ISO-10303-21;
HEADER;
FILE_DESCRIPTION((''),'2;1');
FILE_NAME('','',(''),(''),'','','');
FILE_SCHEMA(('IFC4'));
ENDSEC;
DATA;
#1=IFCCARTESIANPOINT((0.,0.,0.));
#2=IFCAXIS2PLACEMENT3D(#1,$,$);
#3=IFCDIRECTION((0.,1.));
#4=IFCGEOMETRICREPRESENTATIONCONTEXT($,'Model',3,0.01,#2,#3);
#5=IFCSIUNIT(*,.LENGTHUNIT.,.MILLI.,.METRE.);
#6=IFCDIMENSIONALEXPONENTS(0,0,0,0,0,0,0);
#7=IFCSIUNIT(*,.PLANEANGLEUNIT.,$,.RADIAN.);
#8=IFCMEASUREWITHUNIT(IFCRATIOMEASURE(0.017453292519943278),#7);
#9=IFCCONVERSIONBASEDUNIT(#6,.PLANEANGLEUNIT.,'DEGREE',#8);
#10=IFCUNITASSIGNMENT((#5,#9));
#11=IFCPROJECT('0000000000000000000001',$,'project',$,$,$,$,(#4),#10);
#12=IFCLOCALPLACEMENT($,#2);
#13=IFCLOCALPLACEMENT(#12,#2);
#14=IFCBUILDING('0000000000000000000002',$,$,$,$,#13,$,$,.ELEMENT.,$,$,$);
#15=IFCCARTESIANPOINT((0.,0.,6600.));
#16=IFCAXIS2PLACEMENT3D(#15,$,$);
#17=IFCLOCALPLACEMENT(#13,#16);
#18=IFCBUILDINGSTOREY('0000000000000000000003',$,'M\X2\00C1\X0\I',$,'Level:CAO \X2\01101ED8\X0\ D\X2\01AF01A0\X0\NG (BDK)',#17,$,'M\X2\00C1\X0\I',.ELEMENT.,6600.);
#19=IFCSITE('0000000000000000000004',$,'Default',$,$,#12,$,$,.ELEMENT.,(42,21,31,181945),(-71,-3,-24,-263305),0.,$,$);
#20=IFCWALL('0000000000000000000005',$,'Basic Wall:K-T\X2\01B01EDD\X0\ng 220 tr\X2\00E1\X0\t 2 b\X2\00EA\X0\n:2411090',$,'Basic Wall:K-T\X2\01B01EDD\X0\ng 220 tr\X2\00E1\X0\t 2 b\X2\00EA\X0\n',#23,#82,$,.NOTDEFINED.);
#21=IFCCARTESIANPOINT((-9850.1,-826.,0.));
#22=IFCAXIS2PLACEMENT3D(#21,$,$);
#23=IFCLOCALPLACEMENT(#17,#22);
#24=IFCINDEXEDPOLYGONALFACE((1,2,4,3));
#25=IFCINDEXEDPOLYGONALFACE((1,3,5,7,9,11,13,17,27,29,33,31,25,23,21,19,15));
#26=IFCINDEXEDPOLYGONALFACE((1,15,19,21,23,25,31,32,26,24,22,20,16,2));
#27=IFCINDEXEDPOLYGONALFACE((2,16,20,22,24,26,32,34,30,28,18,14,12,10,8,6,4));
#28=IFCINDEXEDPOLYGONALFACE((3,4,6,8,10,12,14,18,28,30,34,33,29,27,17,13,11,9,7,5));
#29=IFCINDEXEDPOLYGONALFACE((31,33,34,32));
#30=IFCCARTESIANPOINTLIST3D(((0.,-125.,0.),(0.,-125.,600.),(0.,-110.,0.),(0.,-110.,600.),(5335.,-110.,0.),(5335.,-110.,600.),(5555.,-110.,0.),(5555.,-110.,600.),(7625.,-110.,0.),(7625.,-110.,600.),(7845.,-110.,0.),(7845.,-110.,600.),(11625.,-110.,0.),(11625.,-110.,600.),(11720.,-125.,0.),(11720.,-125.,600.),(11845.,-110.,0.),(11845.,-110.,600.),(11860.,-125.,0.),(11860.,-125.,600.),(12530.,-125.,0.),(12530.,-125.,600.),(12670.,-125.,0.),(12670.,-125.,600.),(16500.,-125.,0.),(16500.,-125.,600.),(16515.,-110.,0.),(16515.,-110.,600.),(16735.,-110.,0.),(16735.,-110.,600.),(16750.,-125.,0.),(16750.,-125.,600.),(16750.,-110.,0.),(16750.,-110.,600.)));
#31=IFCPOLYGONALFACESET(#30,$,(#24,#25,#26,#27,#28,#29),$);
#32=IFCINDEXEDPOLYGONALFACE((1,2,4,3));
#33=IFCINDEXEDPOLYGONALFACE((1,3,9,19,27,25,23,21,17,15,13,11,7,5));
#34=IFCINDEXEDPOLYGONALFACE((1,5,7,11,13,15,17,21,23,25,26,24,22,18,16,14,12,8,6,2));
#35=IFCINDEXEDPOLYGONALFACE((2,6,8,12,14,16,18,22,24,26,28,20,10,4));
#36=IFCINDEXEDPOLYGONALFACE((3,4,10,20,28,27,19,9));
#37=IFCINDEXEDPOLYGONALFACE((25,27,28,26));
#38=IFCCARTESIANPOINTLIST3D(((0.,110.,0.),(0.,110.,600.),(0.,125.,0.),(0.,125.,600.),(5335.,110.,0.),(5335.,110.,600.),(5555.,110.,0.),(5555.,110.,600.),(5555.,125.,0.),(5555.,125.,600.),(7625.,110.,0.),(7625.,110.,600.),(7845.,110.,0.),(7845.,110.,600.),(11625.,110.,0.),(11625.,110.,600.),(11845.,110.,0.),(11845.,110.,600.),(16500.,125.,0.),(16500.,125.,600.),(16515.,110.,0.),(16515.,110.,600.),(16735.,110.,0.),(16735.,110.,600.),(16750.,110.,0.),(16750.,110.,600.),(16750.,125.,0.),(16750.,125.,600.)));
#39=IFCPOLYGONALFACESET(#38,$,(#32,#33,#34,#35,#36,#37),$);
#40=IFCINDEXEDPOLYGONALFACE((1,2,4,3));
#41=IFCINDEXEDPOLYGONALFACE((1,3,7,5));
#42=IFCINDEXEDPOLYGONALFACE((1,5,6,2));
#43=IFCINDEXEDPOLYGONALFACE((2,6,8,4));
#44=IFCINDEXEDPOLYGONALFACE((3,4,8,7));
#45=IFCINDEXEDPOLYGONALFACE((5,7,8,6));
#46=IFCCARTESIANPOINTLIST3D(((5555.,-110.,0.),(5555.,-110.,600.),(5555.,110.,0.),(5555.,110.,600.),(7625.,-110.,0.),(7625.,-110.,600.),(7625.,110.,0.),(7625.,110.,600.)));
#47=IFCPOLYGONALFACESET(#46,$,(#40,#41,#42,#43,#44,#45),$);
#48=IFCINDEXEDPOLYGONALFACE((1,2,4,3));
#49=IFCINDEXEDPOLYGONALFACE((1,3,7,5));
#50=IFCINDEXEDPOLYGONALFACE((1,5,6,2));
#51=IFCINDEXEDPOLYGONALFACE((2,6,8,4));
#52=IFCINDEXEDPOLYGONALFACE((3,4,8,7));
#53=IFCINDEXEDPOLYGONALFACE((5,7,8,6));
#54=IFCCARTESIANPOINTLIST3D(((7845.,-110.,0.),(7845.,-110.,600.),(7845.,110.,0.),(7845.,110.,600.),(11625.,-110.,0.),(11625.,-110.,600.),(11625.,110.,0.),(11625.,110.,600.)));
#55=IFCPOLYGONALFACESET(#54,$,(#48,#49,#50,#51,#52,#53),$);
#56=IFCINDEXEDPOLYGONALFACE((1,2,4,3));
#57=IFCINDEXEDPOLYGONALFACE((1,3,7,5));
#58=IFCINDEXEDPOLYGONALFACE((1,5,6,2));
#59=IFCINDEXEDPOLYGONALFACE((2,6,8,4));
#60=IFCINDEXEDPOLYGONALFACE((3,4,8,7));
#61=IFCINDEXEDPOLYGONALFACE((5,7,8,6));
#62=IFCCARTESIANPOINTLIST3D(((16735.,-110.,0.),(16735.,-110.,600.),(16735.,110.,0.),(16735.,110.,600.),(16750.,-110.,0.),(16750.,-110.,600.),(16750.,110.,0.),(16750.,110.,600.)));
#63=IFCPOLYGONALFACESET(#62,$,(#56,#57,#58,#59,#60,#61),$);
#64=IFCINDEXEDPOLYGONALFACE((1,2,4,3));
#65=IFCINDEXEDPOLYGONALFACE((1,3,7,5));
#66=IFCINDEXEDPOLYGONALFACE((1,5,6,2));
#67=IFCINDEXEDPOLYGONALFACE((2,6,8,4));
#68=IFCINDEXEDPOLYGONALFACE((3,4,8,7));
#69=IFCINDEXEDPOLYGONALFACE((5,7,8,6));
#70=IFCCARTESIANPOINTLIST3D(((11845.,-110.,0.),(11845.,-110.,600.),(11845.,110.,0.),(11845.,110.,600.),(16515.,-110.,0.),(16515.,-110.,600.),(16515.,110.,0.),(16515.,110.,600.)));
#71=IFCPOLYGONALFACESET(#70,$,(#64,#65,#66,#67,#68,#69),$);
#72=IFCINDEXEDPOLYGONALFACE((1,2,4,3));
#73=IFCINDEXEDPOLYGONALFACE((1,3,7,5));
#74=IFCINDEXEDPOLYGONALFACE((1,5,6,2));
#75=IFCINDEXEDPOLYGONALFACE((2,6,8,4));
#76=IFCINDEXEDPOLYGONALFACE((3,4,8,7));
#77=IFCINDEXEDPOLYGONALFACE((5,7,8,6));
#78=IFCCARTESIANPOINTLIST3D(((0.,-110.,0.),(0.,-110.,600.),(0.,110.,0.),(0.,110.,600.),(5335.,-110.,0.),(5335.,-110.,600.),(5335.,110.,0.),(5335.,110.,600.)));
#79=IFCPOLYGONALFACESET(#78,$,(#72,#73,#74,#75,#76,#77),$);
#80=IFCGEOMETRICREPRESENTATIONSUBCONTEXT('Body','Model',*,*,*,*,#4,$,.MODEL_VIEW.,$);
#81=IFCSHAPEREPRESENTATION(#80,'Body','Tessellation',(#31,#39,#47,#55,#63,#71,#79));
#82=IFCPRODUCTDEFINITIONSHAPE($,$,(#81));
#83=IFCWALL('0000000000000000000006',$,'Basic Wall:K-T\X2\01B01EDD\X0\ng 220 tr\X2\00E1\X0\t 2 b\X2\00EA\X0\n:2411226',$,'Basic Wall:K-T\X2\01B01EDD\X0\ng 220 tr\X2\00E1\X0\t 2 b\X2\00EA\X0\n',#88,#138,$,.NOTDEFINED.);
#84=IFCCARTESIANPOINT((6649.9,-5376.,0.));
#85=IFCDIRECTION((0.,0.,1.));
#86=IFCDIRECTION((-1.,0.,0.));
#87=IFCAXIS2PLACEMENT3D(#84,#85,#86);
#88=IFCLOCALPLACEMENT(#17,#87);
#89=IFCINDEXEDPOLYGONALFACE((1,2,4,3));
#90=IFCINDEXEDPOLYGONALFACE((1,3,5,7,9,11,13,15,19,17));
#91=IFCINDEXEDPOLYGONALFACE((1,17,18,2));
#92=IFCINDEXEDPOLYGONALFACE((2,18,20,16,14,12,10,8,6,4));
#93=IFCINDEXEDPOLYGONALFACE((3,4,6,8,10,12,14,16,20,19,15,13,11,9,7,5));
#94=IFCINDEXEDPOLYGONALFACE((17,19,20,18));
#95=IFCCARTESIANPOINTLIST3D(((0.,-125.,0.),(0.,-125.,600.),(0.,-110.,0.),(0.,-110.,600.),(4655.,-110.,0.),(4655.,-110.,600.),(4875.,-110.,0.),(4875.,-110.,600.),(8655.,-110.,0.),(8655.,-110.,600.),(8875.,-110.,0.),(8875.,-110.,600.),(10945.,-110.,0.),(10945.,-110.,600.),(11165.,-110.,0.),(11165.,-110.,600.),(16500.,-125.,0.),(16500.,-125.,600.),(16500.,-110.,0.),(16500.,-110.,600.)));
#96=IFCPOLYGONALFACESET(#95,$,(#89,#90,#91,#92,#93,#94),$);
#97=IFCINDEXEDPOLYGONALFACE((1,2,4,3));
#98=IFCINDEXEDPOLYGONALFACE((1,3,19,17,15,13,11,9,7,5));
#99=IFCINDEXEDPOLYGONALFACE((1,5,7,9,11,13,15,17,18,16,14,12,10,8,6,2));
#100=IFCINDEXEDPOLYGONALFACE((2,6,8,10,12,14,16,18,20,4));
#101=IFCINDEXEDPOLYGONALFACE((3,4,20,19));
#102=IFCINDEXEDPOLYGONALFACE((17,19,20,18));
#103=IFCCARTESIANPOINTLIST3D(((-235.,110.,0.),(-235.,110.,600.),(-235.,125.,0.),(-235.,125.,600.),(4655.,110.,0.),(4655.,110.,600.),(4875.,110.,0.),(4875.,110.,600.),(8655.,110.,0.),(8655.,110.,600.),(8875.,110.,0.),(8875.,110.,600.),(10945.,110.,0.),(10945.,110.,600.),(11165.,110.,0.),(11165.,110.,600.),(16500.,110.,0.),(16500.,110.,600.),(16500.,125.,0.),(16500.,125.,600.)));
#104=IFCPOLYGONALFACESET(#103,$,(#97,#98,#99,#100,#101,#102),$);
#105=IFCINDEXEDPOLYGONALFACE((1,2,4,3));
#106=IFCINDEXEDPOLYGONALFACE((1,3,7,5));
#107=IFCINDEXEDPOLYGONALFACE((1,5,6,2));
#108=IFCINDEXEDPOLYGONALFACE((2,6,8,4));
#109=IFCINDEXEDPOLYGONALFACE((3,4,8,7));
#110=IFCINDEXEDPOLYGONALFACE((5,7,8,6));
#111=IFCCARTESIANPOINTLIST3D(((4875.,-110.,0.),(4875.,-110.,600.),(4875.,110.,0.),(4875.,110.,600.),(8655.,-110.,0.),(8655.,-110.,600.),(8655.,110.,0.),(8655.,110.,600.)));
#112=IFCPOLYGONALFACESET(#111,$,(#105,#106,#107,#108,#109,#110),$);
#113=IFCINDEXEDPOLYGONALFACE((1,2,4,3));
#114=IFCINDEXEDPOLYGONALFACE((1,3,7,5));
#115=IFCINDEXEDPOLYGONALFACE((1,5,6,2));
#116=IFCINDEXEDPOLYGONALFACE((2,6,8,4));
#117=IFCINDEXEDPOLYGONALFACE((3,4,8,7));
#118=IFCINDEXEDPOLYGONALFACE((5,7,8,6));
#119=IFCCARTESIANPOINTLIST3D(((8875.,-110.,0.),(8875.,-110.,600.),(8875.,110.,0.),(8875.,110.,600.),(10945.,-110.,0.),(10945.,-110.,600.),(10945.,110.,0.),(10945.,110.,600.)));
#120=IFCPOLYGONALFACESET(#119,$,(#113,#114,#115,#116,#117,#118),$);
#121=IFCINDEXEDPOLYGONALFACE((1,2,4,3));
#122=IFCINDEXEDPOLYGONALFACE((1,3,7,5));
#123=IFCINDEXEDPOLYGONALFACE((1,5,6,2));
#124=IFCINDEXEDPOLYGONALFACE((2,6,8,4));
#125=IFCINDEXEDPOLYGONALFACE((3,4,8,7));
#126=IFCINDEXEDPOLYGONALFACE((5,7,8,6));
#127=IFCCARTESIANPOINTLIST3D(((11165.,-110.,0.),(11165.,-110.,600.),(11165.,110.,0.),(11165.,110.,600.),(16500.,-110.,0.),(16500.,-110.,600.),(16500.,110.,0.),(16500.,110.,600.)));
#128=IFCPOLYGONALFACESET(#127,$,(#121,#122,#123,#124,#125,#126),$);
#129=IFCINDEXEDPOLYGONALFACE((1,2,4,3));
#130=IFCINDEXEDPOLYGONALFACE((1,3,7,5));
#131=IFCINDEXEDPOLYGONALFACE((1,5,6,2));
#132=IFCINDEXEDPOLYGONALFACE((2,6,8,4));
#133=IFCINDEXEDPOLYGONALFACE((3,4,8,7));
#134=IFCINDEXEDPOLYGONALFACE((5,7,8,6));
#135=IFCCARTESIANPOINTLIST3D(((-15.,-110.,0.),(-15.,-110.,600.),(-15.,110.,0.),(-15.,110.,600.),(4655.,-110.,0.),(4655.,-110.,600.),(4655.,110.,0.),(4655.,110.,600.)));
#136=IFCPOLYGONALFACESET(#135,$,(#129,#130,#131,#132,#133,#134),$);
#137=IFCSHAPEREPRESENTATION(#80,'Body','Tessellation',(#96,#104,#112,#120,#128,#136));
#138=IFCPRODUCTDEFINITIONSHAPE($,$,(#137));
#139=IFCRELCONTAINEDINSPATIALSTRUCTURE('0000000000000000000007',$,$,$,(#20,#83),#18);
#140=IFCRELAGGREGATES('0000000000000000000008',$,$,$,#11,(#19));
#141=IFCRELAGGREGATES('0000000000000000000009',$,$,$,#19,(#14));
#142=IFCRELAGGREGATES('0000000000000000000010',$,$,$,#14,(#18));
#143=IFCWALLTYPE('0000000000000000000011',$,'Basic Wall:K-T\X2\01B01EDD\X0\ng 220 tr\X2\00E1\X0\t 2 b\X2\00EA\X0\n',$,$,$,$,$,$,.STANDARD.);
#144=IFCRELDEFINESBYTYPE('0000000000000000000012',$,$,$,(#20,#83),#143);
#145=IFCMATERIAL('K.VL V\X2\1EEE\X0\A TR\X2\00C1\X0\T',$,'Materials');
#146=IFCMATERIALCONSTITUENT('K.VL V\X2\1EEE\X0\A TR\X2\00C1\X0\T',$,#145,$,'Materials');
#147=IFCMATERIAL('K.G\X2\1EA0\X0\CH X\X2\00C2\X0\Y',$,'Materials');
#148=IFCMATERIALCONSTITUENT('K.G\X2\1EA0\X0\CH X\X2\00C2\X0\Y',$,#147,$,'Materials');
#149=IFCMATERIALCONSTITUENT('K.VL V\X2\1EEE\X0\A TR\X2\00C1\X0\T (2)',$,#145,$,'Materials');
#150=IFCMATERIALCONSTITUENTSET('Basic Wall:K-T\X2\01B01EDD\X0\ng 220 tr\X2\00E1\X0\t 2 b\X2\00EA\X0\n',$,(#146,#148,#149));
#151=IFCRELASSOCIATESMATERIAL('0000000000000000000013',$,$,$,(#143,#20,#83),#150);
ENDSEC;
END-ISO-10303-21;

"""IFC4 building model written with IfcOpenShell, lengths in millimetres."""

from ifc_helpers import new_model, entity, si_unit, converted_unit, direction, frame, origin, place, context, subcontext, project, spatial, indexed_curve, outline, extrude, material, constituent, constituent_set, type_object, element, save


model = new_model("IFC4")

# Units and contexts
model_context = context("Model", 3, precision=0.01, world=origin(), true_north=direction((0.0, 1.0)))
body_context = subcontext(model_context, "Body", "Model", "MODEL_VIEW")
ifc_project = project(units=[si_unit("LENGTHUNIT", "METRE", prefix="MILLI"), converted_unit("PLANEANGLEUNIT", "DEGREE", entity("IfcRatioMeasure", 0.017453292519943278), si_unit("PLANEANGLEUNIT", "RADIAN"), dimensions=[0, 0, 0, 0, 0, 0, 0])], contexts=[model_context])

# Site, building, storey
site_placement = place(None, origin())
site = spatial("IfcSite", under=ifc_project, at=site_placement, Name="Default", CompositionType="ELEMENT", RefLatitude=(42, 21, 31, 181945), RefLongitude=(-71, -3, -24, -263305), RefElevation=0.0)
building_placement = place(site_placement, origin())
building = spatial("IfcBuilding", under=site, at=building_placement, CompositionType="ELEMENT")
storey_placement = place(building_placement, frame((0.0, 0.0, 6600.0)))
storey = spatial("IfcBuildingStorey", under=building, at=storey_placement, Name="MÁI", ObjectType="Level:CAO ĐỘ DƯƠNG (BDK)", LongName="MÁI", CompositionType="ELEMENT", Elevation=6600.0)

# Walls
ifc_material_1 = material(Name="K.VL VỮA TRÁT", Category="Materials")
ifc_constituent_1 = constituent(ifc_material_1, Name="K.VL VỮA TRÁT", Category="Materials")
ifc_material_2 = material(Name="K.GẠCH XÂY", Category="Materials")
ifc_constituent_2 = constituent(ifc_material_2, Name="K.GẠCH XÂY", Category="Materials")
ifc_constituent_3 = constituent(ifc_material_1, Name="K.VL VỮA TRÁT (2)", Category="Materials")
ifc_constituent_set_1 = constituent_set(constituents=[ifc_constituent_1, ifc_constituent_2, ifc_constituent_3], Name="Basic Wall:K-Tường 220 trát 2 bên")
wall_type_1 = type_object("IfcWallType", Name="Basic Wall:K-Tường 220 trát 2 bên", PredefinedType="STANDARD", material=ifc_constituent_set_1)
wall_1_placement = place(storey_placement, frame((-9850.1, -826.0, 0.0)))
element("IfcWall", 1, at=wall_1_placement, inside=storey, type_object=wall_type_1, material=ifc_constituent_set_1, Name="Basic Wall:K-Tường 220 trát 2 bên:2411090", ObjectType="Basic Wall:K-Tường 220 trát 2 bên", PredefinedType="NOTDEFINED", context=body_context, shape_type="SweptSolid", body=[
    extrude(outline(indexed_curve([(1022.4, -8.8), (1162.4, -8.8), (1832.4, -8.8), (1972.4, -8.8), (5802.4, -8.8), (6052.4, -8.8), (6052.4, 6.2), (6037.4, 6.2), (5817.4, 6.2), (1147.4, 6.2), (927.4, 6.2), (-2852.6, 6.2), (-3072.6, 6.2), (-5142.6, 6.2), (-5362.6, 6.2), (-10697.6, 6.2), (-10697.6, -8.8), (1022.4, -8.8)], self_intersect=False)), frame((10697.6, -116.2, 0.0)), (0.0, 0.0, 1.0), 600.0),
    extrude(outline(indexed_curve([(-6597.5, -10.7), (4347.5, -10.7), (9902.5, -10.7), (9902.5, 4.3), (4567.5, 4.3), (4347.5, 4.3), (2277.5, 4.3), (2057.5, 4.3), (-1722.5, 4.3), (-1942.5, 4.3), (-6612.5, 4.3), (-6832.5, 4.3), (-6847.5, 4.3), (-6847.5, -10.7), (-6597.5, -10.7)], self_intersect=False)), frame((9902.5, 114.3, 0.0), z_axis=(0.0, 0.0, 1.0), x_axis=(-1.0, 0.0, 0.0)), (0.0, 0.0, 1.0), 600.0),
    extrude(outline(indexed_curve([(-1035.0, -110.0), (1035.0, -110.0), (1035.0, 110.0), (-1035.0, 110.0), (-1035.0, -110.0)], self_intersect=False)), frame((6590.0, 0.0, 0.0), z_axis=(0.0, 0.0, 1.0), x_axis=(-1.0, 0.0, 0.0)), (0.0, 0.0, 1.0), 600.0),
    extrude(outline(indexed_curve([(-1890.0, -110.0), (1890.0, -110.0), (1890.0, 110.0), (-1890.0, 110.0), (-1890.0, -110.0)], self_intersect=False)), frame((9735.0, 0.0, 0.0), z_axis=(0.0, 0.0, 1.0), x_axis=(-1.0, 0.0, 0.0)), (0.0, 0.0, 1.0), 600.0),
    extrude(outline(indexed_curve([(-7.5, -110.0), (7.5, -110.0), (7.5, 110.0), (-7.5, 110.0), (-7.5, -110.0)], self_intersect=False)), frame((16742.5, 0.0, 0.0)), (0.0, 0.0, 1.0), 600.0),
    extrude(outline(indexed_curve([(-2335.0, -110.0), (2335.0, -110.0), (2335.0, 110.0), (-2335.0, 110.0), (-2335.0, -110.0)], self_intersect=False)), frame((14180.0, 0.0, 0.0)), (0.0, 0.0, 1.0), 600.0),
    extrude(outline(indexed_curve([(-2667.5, -110.0), (2667.5, -110.0), (2667.5, 110.0), (-2667.5, 110.0), (-2667.5, -110.0)], self_intersect=False)), frame((2667.5, 0.0, 0.0), z_axis=(0.0, 0.0, 1.0), x_axis=(-1.0, 0.0, 0.0)), (0.0, 0.0, 1.0), 600.0),
])
wall_2_placement = place(storey_placement, frame((6649.9, -5376.0, 0.0), z_axis=(0.0, 0.0, 1.0), x_axis=(-1.0, 0.0, 0.0)))
element("IfcWall", 2, at=wall_2_placement, inside=storey, type_object=wall_type_1, material=ifc_constituent_set_1, Name="Basic Wall:K-Tường 220 trát 2 bên:2411226", ObjectType="Basic Wall:K-Tường 220 trát 2 bên", PredefinedType="NOTDEFINED", context=body_context, shape_type="SweptSolid", body=[
    extrude(outline(indexed_curve([(-12.0, -8283.0), (3.0, -8283.0), (3.0, -2948.0), (3.0, -2728.0), (3.0, -658.0), (3.0, -438.0), (3.0, 3342.0), (3.0, 3562.0), (3.0, 8217.0), (-12.0, 8217.0), (-12.0, -8283.0)], self_intersect=False)), frame((8217.0, -113.0, 0.0), z_axis=(0.0, 0.0, 1.0), x_axis=(0.0, 1.0, 0.0)), (0.0, 0.0, 1.0), 600.0),
    extrude(outline(indexed_curve([(-12.0, -8405.0), (3.0, -8405.0), (3.0, -3515.0), (3.0, -3295.0), (3.0, 485.0), (3.0, 705.0), (3.0, 2775.0), (3.0, 2995.0), (3.0, 8330.0), (-12.0, 8330.0), (-12.0, -8405.0)], self_intersect=False)), frame((8170.0, 113.0, 0.0), z_axis=(0.0, 0.0, 1.0), x_axis=(0.0, -1.0, 0.0)), (0.0, 0.0, 1.0), 600.0),
    extrude(outline(indexed_curve([(-1890.0, -110.0), (1890.0, -110.0), (1890.0, 110.0), (-1890.0, 110.0), (-1890.0, -110.0)], self_intersect=False)), frame((6765.0, 0.0, 0.0), z_axis=(0.0, 0.0, 1.0), x_axis=(-1.0, 0.0, 0.0)), (0.0, 0.0, 1.0), 600.0),
    extrude(outline(indexed_curve([(-1035.0, -110.0), (1035.0, -110.0), (1035.0, 110.0), (-1035.0, 110.0), (-1035.0, -110.0)], self_intersect=False)), frame((9910.0, 0.0, 0.0), z_axis=(0.0, 0.0, 1.0), x_axis=(-1.0, 0.0, 0.0)), (0.0, 0.0, 1.0), 600.0),
    extrude(outline(indexed_curve([(-2667.5, -110.0), (2667.5, -110.0), (2667.5, 110.0), (-2667.5, 110.0), (-2667.5, -110.0)], self_intersect=False)), frame((13832.5, 0.0, 0.0)), (0.0, 0.0, 1.0), 600.0),
    extrude(outline(indexed_curve([(-2335.0, -110.0), (2335.0, -110.0), (2335.0, 110.0), (-2335.0, 110.0), (-2335.0, -110.0)], self_intersect=False)), frame((2320.0, 0.0, 0.0), z_axis=(0.0, 0.0, 1.0), x_axis=(-1.0, 0.0, 0.0)), (0.0, 0.0, 1.0), 600.0),
])

save(model, "model.ifc")
